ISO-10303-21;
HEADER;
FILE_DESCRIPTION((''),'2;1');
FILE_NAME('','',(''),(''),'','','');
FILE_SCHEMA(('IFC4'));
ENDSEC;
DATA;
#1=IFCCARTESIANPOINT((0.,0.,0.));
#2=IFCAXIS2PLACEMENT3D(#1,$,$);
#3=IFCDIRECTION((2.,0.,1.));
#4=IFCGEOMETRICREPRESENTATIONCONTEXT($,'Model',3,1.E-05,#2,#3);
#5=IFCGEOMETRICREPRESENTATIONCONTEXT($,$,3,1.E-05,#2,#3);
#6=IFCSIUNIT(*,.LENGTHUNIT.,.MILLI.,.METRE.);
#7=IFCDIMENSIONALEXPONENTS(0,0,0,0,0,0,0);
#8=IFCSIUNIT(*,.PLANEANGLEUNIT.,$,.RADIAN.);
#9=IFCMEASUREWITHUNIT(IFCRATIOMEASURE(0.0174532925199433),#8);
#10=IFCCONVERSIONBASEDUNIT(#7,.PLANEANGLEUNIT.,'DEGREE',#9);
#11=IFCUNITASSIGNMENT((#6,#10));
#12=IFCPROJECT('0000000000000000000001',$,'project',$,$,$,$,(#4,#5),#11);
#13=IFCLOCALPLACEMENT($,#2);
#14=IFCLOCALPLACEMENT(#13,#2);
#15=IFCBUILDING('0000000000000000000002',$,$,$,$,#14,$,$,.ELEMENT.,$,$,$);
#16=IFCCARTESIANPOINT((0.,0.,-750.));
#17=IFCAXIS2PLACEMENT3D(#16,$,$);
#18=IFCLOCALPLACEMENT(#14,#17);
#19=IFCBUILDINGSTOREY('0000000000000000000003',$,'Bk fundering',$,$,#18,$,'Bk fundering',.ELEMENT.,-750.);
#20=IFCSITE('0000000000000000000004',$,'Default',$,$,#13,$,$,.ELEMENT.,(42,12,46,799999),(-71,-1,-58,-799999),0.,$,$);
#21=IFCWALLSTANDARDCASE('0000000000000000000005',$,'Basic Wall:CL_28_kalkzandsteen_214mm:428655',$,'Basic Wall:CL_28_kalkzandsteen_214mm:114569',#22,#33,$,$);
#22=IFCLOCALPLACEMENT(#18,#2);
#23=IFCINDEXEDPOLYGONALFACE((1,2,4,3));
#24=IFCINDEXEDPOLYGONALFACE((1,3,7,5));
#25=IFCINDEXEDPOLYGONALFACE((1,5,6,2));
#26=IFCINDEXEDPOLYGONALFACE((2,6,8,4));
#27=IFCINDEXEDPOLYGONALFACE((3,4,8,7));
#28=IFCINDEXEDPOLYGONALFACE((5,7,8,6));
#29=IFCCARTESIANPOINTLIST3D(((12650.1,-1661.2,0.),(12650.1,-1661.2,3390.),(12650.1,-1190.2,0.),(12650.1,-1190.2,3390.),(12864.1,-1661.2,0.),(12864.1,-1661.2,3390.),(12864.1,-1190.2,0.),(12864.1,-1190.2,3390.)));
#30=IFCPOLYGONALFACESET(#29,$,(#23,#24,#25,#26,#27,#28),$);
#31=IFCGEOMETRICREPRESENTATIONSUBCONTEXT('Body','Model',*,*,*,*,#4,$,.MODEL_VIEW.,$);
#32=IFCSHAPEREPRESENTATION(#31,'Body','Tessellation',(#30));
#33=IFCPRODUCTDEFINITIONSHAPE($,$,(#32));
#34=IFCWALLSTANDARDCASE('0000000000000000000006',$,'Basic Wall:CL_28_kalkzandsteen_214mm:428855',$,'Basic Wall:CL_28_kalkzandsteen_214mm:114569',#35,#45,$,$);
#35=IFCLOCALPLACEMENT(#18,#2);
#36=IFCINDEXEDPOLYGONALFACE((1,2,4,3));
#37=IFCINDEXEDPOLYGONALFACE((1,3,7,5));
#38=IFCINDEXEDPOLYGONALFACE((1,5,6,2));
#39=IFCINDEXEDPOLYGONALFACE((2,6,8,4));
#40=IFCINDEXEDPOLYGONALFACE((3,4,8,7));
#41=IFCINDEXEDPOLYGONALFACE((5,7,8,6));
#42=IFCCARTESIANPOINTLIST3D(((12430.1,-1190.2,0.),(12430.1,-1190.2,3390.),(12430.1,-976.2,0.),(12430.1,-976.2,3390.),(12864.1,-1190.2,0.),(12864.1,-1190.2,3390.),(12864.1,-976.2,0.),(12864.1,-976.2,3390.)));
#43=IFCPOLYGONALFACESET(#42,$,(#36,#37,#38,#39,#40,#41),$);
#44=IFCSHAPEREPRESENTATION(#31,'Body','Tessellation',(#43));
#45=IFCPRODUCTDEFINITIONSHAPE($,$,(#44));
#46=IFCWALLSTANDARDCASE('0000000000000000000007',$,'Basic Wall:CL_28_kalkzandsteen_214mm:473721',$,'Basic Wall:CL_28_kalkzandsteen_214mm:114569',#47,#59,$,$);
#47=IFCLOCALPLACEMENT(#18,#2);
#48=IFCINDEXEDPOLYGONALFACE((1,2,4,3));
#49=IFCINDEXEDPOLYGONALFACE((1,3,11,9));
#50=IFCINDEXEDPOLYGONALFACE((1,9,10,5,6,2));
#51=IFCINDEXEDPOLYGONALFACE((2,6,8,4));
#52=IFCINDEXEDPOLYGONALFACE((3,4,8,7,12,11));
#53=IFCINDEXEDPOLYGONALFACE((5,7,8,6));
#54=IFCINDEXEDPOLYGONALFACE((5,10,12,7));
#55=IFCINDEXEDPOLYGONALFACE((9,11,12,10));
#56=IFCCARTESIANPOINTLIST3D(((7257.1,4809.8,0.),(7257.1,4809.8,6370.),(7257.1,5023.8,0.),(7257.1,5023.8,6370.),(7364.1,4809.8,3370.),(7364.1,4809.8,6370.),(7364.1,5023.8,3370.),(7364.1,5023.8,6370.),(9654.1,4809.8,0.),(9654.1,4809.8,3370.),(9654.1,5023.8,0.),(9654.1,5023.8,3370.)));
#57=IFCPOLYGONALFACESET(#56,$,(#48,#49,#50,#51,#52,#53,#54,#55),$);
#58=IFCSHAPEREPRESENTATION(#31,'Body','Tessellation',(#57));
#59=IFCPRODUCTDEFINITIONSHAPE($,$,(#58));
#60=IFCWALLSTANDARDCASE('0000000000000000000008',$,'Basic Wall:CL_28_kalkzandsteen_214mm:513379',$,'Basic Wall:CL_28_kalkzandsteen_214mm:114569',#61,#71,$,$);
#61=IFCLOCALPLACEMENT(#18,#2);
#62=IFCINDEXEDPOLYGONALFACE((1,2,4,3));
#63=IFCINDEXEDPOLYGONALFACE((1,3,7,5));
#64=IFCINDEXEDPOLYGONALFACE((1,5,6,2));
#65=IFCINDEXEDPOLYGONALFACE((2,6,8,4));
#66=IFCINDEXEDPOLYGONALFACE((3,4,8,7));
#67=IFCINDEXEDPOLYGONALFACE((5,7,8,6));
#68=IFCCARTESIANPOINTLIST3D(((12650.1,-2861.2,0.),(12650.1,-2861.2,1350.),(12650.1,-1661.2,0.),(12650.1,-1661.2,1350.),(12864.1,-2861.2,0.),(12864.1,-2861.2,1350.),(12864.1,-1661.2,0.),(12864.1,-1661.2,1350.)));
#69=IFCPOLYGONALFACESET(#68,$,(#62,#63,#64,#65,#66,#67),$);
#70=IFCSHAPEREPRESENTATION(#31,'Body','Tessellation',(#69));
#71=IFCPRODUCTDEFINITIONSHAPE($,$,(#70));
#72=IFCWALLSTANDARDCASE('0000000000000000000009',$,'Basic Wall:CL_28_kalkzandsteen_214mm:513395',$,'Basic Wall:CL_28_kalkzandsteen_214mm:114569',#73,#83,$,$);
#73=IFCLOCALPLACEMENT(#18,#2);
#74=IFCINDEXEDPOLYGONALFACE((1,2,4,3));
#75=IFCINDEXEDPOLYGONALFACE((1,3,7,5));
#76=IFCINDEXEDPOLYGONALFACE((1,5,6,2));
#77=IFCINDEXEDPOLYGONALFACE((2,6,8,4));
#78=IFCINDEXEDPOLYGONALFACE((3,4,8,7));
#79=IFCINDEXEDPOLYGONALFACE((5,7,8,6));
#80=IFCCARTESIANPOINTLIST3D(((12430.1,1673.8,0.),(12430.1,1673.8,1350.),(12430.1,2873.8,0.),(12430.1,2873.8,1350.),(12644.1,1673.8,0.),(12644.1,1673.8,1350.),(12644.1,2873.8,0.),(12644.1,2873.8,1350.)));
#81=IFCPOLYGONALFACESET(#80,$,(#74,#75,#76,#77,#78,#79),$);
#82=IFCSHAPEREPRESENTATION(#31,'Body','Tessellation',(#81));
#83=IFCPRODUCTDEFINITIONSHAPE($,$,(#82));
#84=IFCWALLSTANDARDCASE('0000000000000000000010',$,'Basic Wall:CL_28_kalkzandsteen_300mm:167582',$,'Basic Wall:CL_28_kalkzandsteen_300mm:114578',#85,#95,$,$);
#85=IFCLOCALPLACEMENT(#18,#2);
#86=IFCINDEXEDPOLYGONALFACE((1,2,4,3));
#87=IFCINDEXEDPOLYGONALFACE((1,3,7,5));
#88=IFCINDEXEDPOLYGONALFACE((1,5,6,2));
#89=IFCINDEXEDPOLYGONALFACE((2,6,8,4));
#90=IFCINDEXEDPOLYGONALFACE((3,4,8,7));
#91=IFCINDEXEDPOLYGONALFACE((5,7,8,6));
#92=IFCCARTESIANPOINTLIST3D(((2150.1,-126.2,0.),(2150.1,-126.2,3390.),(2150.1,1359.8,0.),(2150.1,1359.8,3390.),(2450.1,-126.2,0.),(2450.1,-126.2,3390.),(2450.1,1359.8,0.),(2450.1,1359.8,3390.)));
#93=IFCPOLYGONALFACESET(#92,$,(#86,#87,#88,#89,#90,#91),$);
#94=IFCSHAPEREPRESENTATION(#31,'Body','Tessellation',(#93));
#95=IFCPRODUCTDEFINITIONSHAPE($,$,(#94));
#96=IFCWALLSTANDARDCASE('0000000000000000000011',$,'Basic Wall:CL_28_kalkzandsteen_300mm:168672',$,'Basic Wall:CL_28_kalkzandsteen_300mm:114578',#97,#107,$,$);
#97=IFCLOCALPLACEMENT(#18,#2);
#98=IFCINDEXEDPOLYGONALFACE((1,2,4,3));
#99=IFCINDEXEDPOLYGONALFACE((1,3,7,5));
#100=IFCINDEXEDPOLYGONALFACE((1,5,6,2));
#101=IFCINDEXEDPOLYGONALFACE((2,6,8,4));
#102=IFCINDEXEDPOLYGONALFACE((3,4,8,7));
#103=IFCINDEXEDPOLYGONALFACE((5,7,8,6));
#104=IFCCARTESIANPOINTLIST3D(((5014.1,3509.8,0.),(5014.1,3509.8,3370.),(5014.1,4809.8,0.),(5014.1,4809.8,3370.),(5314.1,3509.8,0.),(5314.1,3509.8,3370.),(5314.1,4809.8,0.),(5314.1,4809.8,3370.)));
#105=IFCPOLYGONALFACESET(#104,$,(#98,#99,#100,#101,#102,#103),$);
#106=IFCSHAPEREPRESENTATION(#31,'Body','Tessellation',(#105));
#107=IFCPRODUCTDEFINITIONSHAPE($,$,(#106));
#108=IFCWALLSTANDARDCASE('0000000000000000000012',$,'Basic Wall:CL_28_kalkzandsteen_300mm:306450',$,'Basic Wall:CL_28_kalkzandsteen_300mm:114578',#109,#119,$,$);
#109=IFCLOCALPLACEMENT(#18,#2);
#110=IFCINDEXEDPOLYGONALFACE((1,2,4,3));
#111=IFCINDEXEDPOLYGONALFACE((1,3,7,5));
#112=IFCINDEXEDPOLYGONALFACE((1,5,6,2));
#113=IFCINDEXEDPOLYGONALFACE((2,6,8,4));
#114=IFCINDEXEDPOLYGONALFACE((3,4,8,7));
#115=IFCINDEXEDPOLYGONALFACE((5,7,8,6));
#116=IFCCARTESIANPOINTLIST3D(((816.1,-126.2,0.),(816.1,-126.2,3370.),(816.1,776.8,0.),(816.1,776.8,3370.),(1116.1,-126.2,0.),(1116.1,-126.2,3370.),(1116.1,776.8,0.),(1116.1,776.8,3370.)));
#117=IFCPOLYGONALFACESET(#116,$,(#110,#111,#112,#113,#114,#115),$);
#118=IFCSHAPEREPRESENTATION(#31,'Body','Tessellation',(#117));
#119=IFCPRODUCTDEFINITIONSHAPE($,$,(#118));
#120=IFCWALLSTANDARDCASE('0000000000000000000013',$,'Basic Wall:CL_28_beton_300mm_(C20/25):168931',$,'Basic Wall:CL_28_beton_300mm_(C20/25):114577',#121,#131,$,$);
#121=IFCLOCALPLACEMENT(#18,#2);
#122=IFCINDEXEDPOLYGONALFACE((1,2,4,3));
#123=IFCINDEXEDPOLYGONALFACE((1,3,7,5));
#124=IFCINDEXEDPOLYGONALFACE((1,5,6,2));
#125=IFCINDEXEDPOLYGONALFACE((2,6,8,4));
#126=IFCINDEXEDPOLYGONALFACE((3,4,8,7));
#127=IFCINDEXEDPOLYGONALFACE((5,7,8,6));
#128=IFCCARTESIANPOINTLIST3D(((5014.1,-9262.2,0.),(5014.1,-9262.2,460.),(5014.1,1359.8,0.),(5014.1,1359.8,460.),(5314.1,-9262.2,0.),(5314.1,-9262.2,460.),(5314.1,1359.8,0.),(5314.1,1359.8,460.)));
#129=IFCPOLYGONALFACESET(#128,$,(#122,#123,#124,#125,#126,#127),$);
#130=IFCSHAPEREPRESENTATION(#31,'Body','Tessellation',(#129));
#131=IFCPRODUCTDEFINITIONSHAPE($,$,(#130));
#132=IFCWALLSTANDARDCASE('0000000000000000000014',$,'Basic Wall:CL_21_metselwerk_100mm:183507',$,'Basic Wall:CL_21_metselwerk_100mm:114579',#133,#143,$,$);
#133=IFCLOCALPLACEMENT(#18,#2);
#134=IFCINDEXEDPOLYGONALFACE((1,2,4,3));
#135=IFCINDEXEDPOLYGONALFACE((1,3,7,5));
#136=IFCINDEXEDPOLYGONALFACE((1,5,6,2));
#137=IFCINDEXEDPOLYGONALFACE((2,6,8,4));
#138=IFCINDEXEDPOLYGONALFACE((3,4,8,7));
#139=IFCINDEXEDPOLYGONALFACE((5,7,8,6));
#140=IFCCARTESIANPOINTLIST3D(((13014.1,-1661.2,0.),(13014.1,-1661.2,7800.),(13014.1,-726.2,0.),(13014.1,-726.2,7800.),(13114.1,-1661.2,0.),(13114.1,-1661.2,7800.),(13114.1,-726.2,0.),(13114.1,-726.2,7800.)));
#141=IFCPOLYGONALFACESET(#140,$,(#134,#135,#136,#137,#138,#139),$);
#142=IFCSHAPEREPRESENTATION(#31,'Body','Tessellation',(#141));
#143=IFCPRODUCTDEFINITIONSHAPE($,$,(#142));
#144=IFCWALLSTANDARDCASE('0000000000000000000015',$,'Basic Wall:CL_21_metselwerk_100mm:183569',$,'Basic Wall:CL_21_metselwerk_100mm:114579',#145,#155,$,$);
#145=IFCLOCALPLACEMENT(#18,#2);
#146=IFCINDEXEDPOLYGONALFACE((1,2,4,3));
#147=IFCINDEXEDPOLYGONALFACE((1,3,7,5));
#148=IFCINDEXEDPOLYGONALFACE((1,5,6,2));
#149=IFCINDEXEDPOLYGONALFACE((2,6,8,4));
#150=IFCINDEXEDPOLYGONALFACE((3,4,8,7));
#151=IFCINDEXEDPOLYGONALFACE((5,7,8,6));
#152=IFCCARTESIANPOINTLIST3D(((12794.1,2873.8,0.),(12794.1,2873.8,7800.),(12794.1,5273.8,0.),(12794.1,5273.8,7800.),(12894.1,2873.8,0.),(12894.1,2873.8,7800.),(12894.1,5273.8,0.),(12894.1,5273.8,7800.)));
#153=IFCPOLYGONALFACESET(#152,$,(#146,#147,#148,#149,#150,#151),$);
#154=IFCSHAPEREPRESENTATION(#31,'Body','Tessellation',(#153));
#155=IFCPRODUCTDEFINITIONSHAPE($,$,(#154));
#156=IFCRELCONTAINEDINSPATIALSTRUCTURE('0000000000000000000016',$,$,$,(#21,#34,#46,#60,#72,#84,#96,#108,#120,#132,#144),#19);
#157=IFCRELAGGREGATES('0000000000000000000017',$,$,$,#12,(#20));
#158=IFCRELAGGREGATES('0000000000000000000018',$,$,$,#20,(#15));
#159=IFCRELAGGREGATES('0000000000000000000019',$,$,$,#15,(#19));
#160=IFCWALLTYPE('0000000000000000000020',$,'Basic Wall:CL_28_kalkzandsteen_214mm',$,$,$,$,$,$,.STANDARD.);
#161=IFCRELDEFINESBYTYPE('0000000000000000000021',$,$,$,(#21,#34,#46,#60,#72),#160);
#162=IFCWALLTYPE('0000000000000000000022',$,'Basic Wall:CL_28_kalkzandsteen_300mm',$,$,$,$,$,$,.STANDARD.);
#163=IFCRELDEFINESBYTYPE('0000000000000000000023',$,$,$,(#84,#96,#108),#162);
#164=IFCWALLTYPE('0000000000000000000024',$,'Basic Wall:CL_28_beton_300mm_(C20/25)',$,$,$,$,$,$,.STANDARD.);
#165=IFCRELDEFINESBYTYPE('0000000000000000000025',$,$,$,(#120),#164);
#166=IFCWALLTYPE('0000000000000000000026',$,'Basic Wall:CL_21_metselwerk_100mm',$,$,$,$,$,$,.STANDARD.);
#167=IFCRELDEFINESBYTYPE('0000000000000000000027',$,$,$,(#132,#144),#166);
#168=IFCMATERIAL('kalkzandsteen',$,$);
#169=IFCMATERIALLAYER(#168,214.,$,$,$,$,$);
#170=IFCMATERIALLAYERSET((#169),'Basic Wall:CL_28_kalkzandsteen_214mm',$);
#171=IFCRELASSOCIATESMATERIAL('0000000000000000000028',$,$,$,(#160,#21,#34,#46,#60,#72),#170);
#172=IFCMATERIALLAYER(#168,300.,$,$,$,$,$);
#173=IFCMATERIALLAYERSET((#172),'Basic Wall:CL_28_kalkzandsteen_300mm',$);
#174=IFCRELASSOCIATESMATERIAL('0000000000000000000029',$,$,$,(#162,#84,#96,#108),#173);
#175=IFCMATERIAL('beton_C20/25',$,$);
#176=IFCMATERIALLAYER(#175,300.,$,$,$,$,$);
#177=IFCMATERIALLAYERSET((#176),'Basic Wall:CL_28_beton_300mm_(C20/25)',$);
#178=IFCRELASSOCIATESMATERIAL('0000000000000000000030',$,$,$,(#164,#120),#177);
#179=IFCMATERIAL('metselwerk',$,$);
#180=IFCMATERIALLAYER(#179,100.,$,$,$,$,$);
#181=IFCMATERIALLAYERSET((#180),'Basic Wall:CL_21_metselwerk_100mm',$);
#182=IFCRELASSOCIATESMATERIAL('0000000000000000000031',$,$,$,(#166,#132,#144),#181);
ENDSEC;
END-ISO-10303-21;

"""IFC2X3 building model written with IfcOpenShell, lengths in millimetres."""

from ifc_helpers import new_model, entity, si_unit, converted_unit, direction, frame, frame_2d, origin, place, context, subcontext, project, spatial, polyline, rectangle, extrude, clip, bounded_halfspace, material, layer, layer_set, layer_usage, type_object, element, save


model = new_model("IFC2X3")

# Units and contexts
model_context = context("Model", 3, precision=1e-05, world=origin(), true_north=direction((2.0, 0.0, 1.0)))
context_of_model = context(None, 3, precision=1e-05, world=origin(), true_north=direction((2.0, 0.0, 1.0)))
body_context = subcontext(model_context, "Body", "Model", "MODEL_VIEW")
ifc_project = project(units=[si_unit("LENGTHUNIT", "METRE", prefix="MILLI"), converted_unit("PLANEANGLEUNIT", "DEGREE", entity("IfcRatioMeasure", 0.0174532925199433), si_unit("PLANEANGLEUNIT", "RADIAN"), dimensions=[0, 0, 0, 0, 0, 0, 0])], contexts=[model_context, context_of_model])

# Site, building, storey
site_placement = place(None, origin())
site = spatial("IfcSite", under=ifc_project, at=site_placement, Name="Default", CompositionType="ELEMENT", RefLatitude=(42, 12, 46, 799999), RefLongitude=(-71, -1, -58, -799999), RefElevation=0.0)
building_placement = place(site_placement, origin())
building = spatial("IfcBuilding", under=site, at=building_placement, CompositionType="ELEMENT")
storey_placement = place(building_placement, frame((0.0, 0.0, -750.0)))
storey = spatial("IfcBuildingStorey", under=building, at=storey_placement, Name="Bk fundering", LongName="Bk fundering", CompositionType="ELEMENT", Elevation=-750.0)

# Shared definitions
ifc_material_1 = material(Name="kalkzandsteen")
ifc_layer_1 = layer(ifc_material_1, 214.0)
ifc_layer_set_1 = layer_set([ifc_layer_1], Name="Basic Wall:CL_28_kalkzandsteen_214mm")
wall_type_1 = type_object("IfcWallType", Name="Basic Wall:CL_28_kalkzandsteen_214mm", PredefinedType="STANDARD", material=ifc_layer_set_1)

# Walls
ifc_layer_usage_1 = layer_usage(ifc_layer_set_1, "AXIS2", "NEGATIVE", 107.0)
wall_1_placement = place(storey_placement, frame((12757.1, -1661.2, 0.0), z_axis=(0.0, 0.0, 1.0), x_axis=(0.0, 1.0, 0.0)))
element("IfcWallStandardCase", 1, at=wall_1_placement, inside=storey, type_object=wall_type_1, material=ifc_layer_usage_1, Name="Basic Wall:CL_28_kalkzandsteen_214mm:428655", ObjectType="Basic Wall:CL_28_kalkzandsteen_214mm:114569", context=body_context, shape_type="SweptSolid", body=[
    extrude(rectangle(XDim=471.0, YDim=214.0, at=frame_2d((235.5, 0.0), x_axis=(-1.0, 0.0))), origin(), (0.0, 0.0, 1.0), 3390.0),
])
ifc_layer_usage_2 = layer_usage(ifc_layer_set_1, "AXIS2", "NEGATIVE", 107.0)
wall_2_placement = place(storey_placement, frame((12864.1, -1083.2, 0.0), z_axis=(0.0, 0.0, 1.0), x_axis=(-1.0, 0.0, 0.0)))
element("IfcWallStandardCase", 2, at=wall_2_placement, inside=storey, type_object=wall_type_1, material=ifc_layer_usage_2, Name="Basic Wall:CL_28_kalkzandsteen_214mm:428855", ObjectType="Basic Wall:CL_28_kalkzandsteen_214mm:114569", context=body_context, shape_type="SweptSolid", body=[
    extrude(rectangle(XDim=434.0, YDim=214.0, at=frame_2d((217.0, 0.0), x_axis=(-1.0, 0.0))), origin(), (0.0, 0.0, 1.0), 3390.0),
])
ifc_layer_usage_3 = layer_usage(ifc_layer_set_1, "AXIS2", "NEGATIVE", 107.0)
wall_3_placement = place(storey_placement, frame((9654.1, 4916.8, 0.0), z_axis=(0.0, 0.0, 1.0), x_axis=(-1.0, 0.0, 0.0)))
element("IfcWallStandardCase", 3, at=wall_3_placement, inside=storey, type_object=wall_type_1, material=ifc_layer_usage_3, Name="Basic Wall:CL_28_kalkzandsteen_214mm:473721", ObjectType="Basic Wall:CL_28_kalkzandsteen_214mm:114569", context=body_context, shape_type="Clipping", body=[
    clip(clip(extrude(rectangle(XDim=2397.0, YDim=214.0, at=frame_2d((1198.5, 0.0), x_axis=(-1.0, 0.0))), origin(), (0.0, 0.0, 1.0), 6370.0), bounded_halfspace(frame((0.0, -107.0, 6370.0), z_axis=(0.0, 0.0, -1.0), x_axis=(-1.0, 0.0, 0.0)), True, frame((0.0, -107.0, 6370.0)), polyline([(0.0, 0.0), (2397.0, 0.0), (2397.0, 214.0), (0.0, 214.0), (0.0, 0.0)]))), bounded_halfspace(frame((0.0, -107.0, 3370.0), z_axis=(0.0, 0.0, -1.0), x_axis=(-1.0, 0.0, 0.0)), True, frame((0.0, -107.0, 3370.0), z_axis=(0.0, 0.0, -1.0), x_axis=(-1.0, 0.0, 0.0)), polyline([(0.0, 0.0), (0.0, 214.0), (-2290.0, 214.0), (-2290.0, 0.0), (0.0, 0.0)]))),
])
ifc_layer_usage_4 = layer_usage(ifc_layer_set_1, "AXIS2", "NEGATIVE", 107.0)
wall_4_placement = place(storey_placement, frame((12757.1, -2861.2, 0.0), z_axis=(0.0, 0.0, 1.0), x_axis=(0.0, 1.0, 0.0)))
element("IfcWallStandardCase", 4, at=wall_4_placement, inside=storey, type_object=wall_type_1, material=ifc_layer_usage_4, Name="Basic Wall:CL_28_kalkzandsteen_214mm:513379", ObjectType="Basic Wall:CL_28_kalkzandsteen_214mm:114569", context=body_context, shape_type="SweptSolid", body=[
    extrude(rectangle(XDim=1200.0, YDim=214.0, at=frame_2d((600.0, 0.0), x_axis=(-1.0, 0.0))), origin(), (0.0, 0.0, 1.0), 1350.0),
])
ifc_layer_usage_5 = layer_usage(ifc_layer_set_1, "AXIS2", "NEGATIVE", 107.0)
wall_5_placement = place(storey_placement, frame((12537.1, 1673.8, 0.0), z_axis=(0.0, 0.0, 1.0), x_axis=(0.0, 1.0, 0.0)))
element("IfcWallStandardCase", 5, at=wall_5_placement, inside=storey, type_object=wall_type_1, material=ifc_layer_usage_5, Name="Basic Wall:CL_28_kalkzandsteen_214mm:513395", ObjectType="Basic Wall:CL_28_kalkzandsteen_214mm:114569", context=body_context, shape_type="SweptSolid", body=[
    extrude(rectangle(XDim=1200.0, YDim=214.0, at=frame_2d((600.0, 0.0), x_axis=(-1.0, 0.0))), origin(), (0.0, 0.0, 1.0), 1350.0),
])
ifc_layer_2 = layer(ifc_material_1, 300.0)
ifc_layer_set_2 = layer_set([ifc_layer_2], Name="Basic Wall:CL_28_kalkzandsteen_300mm")
ifc_layer_usage_6 = layer_usage(ifc_layer_set_2, "AXIS2", "NEGATIVE", 150.0)
wall_type_2 = type_object("IfcWallType", Name="Basic Wall:CL_28_kalkzandsteen_300mm", PredefinedType="STANDARD", material=ifc_layer_set_2)
wall_6_placement = place(storey_placement, frame((2300.1, -126.2, 0.0), z_axis=(0.0, 0.0, 1.0), x_axis=(0.0, 1.0, 0.0)))
element("IfcWallStandardCase", 6, at=wall_6_placement, inside=storey, type_object=wall_type_2, material=ifc_layer_usage_6, Name="Basic Wall:CL_28_kalkzandsteen_300mm:167582", ObjectType="Basic Wall:CL_28_kalkzandsteen_300mm:114578", context=body_context, shape_type="SweptSolid", body=[
    extrude(rectangle(XDim=1486.0, YDim=300.0, at=frame_2d((743.0, 0.0), x_axis=(-1.0, 0.0))), origin(), (0.0, 0.0, 1.0), 3390.0),
])
ifc_layer_usage_7 = layer_usage(ifc_layer_set_2, "AXIS2", "NEGATIVE", 150.0)
wall_7_placement = place(storey_placement, frame((5164.1, 4809.8, 0.0), z_axis=(0.0, 0.0, 1.0), x_axis=(0.0, -1.0, 0.0)))
element("IfcWallStandardCase", 7, at=wall_7_placement, inside=storey, type_object=wall_type_2, material=ifc_layer_usage_7, Name="Basic Wall:CL_28_kalkzandsteen_300mm:168672", ObjectType="Basic Wall:CL_28_kalkzandsteen_300mm:114578", context=body_context, shape_type="Clipping", body=[
    clip(extrude(rectangle(XDim=1300.0, YDim=300.0, at=frame_2d((650.0, 0.0), x_axis=(-1.0, 0.0))), origin(), (0.0, 0.0, 1.0), 3370.0), bounded_halfspace(frame((0.0, -150.0, 3370.0), z_axis=(0.0, 0.0, -1.0), x_axis=(0.0, 1.0, 0.0)), True, frame((0.0, -150.0, 3370.0)), polyline([(0.0, 0.0), (1300.0, 0.0), (1300.0, 300.0), (0.0, 300.0), (0.0, 0.0)]))),
])
ifc_layer_usage_8 = layer_usage(ifc_layer_set_2, "AXIS2", "NEGATIVE", 150.0)
wall_8_placement = place(storey_placement, frame((966.1, -126.2, 0.0), z_axis=(0.0, 0.0, 1.0), x_axis=(0.0, 1.0, 0.0)))
element("IfcWallStandardCase", 8, at=wall_8_placement, inside=storey, type_object=wall_type_2, material=ifc_layer_usage_8, Name="Basic Wall:CL_28_kalkzandsteen_300mm:306450", ObjectType="Basic Wall:CL_28_kalkzandsteen_300mm:114578", context=body_context, shape_type="Clipping", body=[
    clip(extrude(rectangle(XDim=903.0, YDim=300.0, at=frame_2d((451.5, 0.0), x_axis=(-1.0, 0.0))), origin(), (0.0, 0.0, 1.0), 3370.0), bounded_halfspace(frame((0.0, -150.0, 3370.0), z_axis=(0.0, 0.0, -1.0), x_axis=(0.0, -1.0, 0.0)), True, frame((0.0, -150.0, 3370.0)), polyline([(0.0, 0.0), (903.0, 0.0), (903.0, 300.0), (300.0, 300.0), (0.0, 300.0), (0.0, 0.0)]))),
])
ifc_material_2 = material(Name="beton_C20/25")
ifc_layer_3 = layer(ifc_material_2, 300.0)
ifc_layer_set_3 = layer_set([ifc_layer_3], Name="Basic Wall:CL_28_beton_300mm_(C20/25)")
ifc_layer_usage_9 = layer_usage(ifc_layer_set_3, "AXIS2", "NEGATIVE", 150.0)
wall_type_3 = type_object("IfcWallType", Name="Basic Wall:CL_28_beton_300mm_(C20/25)", PredefinedType="STANDARD", material=ifc_layer_set_3)
wall_9_placement = place(storey_placement, frame((5164.1, 1359.8, 0.0), z_axis=(0.0, 0.0, 1.0), x_axis=(0.0, -1.0, 0.0)))
element("IfcWallStandardCase", 9, at=wall_9_placement, inside=storey, type_object=wall_type_3, material=ifc_layer_usage_9, Name="Basic Wall:CL_28_beton_300mm_(C20/25):168931", ObjectType="Basic Wall:CL_28_beton_300mm_(C20/25):114577", context=body_context, shape_type="SweptSolid", body=[
    extrude(rectangle(XDim=10622.0, YDim=300.0, at=frame_2d((5311.0, 0.0), x_axis=(-1.0, 0.0))), origin(), (0.0, 0.0, 1.0), 460.0),
])
ifc_material_3 = material(Name="metselwerk")
ifc_layer_4 = layer(ifc_material_3, 100.0)
ifc_layer_set_4 = layer_set([ifc_layer_4], Name="Basic Wall:CL_21_metselwerk_100mm")
ifc_layer_usage_10 = layer_usage(ifc_layer_set_4, "AXIS2", "NEGATIVE", 50.0)
wall_type_4 = type_object("IfcWallType", Name="Basic Wall:CL_21_metselwerk_100mm", PredefinedType="STANDARD", material=ifc_layer_set_4)
wall_10_placement = place(storey_placement, frame((13064.1, -1661.2, 0.0), z_axis=(0.0, 0.0, 1.0), x_axis=(0.0, 1.0, 0.0)))
element("IfcWallStandardCase", 10, at=wall_10_placement, inside=storey, type_object=wall_type_4, material=ifc_layer_usage_10, Name="Basic Wall:CL_21_metselwerk_100mm:183507", ObjectType="Basic Wall:CL_21_metselwerk_100mm:114579", context=body_context, shape_type="SweptSolid", body=[
    extrude(rectangle(XDim=935.0, YDim=100.0, at=frame_2d((467.5, 0.0), x_axis=(-1.0, 0.0))), origin(), (0.0, 0.0, 1.0), 7800.0),
])
ifc_layer_usage_11 = layer_usage(ifc_layer_set_4, "AXIS2", "NEGATIVE", 50.0)
wall_11_placement = place(storey_placement, frame((12844.1, 2873.8, 0.0), z_axis=(0.0, 0.0, 1.0), x_axis=(0.0, 1.0, 0.0)))
element("IfcWallStandardCase", 11, at=wall_11_placement, inside=storey, type_object=wall_type_4, material=ifc_layer_usage_11, Name="Basic Wall:CL_21_metselwerk_100mm:183569", ObjectType="Basic Wall:CL_21_metselwerk_100mm:114579", context=body_context, shape_type="SweptSolid", body=[
    extrude(rectangle(XDim=2400.0, YDim=100.0, at=frame_2d((1200.0, 0.0), x_axis=(-1.0, 0.0))), origin(), (0.0, 0.0, 1.0), 7800.0),
])

save(model, "model.ifc")
